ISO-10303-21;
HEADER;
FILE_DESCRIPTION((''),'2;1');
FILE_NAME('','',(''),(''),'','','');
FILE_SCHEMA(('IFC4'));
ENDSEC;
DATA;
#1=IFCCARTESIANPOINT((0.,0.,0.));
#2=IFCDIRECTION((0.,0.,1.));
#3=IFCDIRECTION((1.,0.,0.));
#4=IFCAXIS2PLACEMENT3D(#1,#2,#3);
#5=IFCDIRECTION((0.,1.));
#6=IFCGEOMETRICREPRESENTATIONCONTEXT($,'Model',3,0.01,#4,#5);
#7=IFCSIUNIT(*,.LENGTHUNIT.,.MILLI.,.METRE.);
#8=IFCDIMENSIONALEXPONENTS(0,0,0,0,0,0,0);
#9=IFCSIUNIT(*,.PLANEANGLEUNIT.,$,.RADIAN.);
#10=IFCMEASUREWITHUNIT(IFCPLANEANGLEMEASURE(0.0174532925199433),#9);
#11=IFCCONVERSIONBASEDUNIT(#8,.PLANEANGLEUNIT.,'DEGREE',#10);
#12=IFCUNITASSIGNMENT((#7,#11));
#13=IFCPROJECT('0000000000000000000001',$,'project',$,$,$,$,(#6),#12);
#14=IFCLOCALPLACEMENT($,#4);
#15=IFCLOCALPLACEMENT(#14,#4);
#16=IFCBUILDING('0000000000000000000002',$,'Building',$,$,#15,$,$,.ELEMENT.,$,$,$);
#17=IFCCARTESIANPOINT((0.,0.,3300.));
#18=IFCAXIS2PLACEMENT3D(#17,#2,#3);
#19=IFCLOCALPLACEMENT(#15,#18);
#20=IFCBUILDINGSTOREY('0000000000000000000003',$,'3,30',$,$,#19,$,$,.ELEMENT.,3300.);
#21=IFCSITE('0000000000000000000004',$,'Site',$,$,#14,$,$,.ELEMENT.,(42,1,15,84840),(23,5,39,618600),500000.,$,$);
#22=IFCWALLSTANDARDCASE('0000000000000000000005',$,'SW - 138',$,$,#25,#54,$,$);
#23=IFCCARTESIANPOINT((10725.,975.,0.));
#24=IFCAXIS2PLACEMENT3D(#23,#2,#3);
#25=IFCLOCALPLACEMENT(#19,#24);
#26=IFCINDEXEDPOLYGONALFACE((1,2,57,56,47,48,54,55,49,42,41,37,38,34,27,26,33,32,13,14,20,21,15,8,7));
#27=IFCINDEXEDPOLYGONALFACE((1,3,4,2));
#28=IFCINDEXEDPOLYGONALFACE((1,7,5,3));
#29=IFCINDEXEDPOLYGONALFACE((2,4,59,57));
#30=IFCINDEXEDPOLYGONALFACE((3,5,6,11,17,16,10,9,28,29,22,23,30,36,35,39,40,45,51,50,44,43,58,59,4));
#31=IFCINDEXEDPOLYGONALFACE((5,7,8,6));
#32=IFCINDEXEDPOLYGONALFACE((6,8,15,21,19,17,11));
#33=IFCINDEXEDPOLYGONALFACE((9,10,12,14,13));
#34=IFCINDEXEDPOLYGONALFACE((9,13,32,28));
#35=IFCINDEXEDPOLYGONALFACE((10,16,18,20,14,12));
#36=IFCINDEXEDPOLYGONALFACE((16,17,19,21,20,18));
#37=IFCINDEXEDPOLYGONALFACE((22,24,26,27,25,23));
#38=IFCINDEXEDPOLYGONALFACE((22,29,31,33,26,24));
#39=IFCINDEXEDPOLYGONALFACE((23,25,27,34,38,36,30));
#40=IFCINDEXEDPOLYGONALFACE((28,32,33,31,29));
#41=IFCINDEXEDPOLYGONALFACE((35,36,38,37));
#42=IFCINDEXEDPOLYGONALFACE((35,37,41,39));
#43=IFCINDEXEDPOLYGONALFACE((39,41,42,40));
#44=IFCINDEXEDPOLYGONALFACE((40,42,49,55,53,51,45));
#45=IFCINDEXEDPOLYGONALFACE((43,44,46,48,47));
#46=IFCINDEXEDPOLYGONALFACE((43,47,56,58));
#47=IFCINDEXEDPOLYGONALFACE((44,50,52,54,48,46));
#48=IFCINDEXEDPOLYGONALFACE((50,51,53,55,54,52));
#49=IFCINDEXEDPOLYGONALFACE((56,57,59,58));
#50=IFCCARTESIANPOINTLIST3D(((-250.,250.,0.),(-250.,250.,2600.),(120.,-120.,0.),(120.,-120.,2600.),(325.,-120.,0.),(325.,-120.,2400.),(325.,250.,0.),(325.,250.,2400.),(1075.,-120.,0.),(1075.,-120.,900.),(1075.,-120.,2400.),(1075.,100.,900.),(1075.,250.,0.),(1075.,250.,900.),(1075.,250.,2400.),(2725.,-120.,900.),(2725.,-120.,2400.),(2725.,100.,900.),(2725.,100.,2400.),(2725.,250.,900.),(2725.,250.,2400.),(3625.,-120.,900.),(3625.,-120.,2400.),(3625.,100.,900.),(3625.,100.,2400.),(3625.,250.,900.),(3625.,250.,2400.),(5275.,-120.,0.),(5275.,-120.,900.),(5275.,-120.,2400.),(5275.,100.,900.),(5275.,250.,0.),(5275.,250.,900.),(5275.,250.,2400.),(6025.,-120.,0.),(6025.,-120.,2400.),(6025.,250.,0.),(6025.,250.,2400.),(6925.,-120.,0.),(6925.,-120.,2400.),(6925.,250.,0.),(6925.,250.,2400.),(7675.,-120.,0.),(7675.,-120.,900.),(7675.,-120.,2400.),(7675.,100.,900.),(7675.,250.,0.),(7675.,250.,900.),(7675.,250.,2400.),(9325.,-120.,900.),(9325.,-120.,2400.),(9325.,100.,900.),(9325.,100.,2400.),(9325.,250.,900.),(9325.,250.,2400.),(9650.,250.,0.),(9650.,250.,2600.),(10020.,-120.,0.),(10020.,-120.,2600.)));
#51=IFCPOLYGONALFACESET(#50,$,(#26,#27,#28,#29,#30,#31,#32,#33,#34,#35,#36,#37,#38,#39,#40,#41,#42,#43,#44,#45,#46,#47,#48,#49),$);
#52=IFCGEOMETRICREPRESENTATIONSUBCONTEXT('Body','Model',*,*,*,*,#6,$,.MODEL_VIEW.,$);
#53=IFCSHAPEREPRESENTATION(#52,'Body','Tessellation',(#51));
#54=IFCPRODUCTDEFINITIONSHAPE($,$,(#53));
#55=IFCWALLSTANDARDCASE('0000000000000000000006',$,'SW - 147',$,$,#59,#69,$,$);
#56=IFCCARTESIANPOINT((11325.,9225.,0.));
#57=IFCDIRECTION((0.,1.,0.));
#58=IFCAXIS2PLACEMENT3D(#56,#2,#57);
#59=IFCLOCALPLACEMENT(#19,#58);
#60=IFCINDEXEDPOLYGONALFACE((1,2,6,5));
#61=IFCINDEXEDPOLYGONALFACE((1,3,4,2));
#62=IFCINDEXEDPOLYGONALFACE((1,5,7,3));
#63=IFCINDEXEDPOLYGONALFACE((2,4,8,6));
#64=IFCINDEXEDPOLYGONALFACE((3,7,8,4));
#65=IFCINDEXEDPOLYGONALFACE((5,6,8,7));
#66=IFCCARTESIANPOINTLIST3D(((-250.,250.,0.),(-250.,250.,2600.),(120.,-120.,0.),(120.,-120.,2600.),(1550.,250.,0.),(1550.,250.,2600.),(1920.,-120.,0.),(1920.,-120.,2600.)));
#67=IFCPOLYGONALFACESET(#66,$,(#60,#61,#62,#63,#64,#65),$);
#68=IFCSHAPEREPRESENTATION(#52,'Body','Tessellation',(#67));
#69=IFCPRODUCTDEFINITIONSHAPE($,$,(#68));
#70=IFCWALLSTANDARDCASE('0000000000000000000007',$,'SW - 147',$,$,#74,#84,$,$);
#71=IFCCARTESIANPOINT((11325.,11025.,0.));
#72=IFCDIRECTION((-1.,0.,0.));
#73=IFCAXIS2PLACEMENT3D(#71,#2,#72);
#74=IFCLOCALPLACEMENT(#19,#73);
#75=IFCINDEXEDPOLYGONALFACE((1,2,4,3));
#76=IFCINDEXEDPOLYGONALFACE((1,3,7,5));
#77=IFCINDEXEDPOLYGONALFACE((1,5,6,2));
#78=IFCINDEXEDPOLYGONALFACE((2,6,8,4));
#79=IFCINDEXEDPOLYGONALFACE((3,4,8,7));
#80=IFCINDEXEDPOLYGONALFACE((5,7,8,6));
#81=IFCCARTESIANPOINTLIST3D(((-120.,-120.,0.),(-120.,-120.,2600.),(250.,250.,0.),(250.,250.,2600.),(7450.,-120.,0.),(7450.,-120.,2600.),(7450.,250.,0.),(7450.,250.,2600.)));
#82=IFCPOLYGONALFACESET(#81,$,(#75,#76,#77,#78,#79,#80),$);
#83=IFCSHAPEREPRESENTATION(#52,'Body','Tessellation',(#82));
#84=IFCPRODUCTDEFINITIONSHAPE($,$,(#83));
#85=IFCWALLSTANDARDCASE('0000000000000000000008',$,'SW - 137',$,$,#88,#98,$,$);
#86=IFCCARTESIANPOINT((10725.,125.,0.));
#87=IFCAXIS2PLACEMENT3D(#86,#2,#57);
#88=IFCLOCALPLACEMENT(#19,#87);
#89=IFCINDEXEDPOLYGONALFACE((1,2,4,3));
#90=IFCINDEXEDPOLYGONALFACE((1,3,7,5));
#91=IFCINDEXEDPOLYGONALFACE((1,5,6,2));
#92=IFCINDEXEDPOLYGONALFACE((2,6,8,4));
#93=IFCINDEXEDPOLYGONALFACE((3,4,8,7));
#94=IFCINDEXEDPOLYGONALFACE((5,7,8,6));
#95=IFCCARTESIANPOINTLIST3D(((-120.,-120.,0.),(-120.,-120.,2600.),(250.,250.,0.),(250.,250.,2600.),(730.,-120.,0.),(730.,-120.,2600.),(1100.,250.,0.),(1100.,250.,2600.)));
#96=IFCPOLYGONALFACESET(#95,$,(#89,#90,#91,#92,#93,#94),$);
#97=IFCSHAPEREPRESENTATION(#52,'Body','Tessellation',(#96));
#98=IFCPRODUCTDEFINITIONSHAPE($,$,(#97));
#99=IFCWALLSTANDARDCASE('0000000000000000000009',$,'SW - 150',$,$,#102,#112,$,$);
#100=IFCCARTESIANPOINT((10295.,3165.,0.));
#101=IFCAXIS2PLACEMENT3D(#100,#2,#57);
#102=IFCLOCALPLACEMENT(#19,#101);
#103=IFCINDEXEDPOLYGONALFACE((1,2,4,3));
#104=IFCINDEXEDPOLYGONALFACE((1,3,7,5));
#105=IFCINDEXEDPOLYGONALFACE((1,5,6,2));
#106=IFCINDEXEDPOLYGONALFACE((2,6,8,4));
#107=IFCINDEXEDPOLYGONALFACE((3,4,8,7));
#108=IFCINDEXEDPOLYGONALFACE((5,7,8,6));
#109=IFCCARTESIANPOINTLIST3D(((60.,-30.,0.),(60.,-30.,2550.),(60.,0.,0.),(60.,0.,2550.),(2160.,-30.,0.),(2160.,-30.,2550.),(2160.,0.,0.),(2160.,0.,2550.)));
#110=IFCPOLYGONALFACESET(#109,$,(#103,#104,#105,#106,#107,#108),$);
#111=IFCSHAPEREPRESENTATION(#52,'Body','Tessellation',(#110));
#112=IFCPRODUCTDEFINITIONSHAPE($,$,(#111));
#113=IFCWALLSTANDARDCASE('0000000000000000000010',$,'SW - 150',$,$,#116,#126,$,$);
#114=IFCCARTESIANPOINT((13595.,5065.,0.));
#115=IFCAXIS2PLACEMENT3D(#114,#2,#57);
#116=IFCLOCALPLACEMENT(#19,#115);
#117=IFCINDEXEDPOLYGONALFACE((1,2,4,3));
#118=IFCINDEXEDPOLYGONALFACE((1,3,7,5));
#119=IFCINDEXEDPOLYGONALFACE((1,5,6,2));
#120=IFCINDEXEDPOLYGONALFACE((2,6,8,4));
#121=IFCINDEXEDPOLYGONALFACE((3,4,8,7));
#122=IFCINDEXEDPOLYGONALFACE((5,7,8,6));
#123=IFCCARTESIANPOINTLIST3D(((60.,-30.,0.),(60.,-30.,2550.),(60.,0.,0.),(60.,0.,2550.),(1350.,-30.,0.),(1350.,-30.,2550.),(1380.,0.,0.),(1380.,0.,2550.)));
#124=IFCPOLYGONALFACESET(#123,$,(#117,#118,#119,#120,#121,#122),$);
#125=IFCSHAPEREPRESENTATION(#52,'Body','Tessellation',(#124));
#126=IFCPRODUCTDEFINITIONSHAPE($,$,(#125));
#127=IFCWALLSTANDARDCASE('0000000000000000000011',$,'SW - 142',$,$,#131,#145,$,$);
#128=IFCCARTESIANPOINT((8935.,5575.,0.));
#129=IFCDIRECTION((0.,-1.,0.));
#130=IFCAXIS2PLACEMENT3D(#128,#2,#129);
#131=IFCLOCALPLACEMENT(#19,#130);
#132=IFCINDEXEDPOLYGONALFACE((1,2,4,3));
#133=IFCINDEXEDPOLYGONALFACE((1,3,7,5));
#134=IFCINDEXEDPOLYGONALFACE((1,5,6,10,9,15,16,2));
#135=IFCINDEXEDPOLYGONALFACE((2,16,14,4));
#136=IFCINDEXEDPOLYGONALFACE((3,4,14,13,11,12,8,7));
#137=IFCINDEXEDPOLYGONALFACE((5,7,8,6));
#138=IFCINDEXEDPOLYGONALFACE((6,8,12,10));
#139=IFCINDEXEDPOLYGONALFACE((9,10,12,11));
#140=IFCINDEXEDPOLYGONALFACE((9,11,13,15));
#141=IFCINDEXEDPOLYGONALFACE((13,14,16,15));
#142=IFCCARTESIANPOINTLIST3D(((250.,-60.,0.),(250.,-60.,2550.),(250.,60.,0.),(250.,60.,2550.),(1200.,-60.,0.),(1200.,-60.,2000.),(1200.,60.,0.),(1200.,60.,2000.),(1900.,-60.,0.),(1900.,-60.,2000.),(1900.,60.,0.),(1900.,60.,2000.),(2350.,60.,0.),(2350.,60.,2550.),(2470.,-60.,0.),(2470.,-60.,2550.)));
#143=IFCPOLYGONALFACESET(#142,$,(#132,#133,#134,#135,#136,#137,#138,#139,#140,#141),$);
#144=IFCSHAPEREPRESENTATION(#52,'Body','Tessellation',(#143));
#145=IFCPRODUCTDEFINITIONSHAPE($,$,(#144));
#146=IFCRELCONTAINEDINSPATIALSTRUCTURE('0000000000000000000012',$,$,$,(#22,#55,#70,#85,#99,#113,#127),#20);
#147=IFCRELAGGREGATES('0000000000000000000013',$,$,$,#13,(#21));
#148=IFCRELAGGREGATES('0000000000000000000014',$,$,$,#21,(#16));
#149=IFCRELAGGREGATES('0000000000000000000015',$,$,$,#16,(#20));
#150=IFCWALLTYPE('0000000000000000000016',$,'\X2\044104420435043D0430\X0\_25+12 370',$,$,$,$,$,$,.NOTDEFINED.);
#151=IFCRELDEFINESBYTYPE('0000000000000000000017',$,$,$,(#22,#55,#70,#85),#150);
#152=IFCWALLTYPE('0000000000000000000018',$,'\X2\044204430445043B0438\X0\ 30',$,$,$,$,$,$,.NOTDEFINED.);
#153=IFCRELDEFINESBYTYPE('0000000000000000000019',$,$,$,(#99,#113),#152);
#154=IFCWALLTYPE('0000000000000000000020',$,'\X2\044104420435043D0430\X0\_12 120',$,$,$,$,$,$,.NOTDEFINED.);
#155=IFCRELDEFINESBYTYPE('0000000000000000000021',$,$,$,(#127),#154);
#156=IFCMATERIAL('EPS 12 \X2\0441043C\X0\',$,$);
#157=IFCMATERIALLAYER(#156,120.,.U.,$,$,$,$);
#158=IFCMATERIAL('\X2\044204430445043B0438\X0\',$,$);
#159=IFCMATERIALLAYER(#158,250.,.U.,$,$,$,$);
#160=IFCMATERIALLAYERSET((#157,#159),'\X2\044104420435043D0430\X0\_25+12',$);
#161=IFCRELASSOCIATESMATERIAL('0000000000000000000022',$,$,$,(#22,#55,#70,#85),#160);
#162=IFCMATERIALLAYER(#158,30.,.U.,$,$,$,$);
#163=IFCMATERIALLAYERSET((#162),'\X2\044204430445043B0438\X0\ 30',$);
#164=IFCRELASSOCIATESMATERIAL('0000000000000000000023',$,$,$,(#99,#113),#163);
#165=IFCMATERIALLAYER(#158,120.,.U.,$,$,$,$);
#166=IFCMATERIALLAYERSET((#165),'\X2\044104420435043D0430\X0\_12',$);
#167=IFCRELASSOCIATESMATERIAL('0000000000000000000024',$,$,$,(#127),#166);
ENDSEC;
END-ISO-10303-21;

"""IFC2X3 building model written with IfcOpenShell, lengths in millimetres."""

from ifc_helpers import new_model, entity, si_unit, converted_unit, direction, frame, origin_with_axes, origin_2d_with_axis, place, context, subcontext, project, spatial, polyline, rectangle, outline, extrude, material, layer, layer_set, layer_usage, type_object, element, save


model = new_model("IFC2X3")

# Units and contexts
model_context = context("Model", 3, precision=0.01, world=origin_with_axes(), true_north=direction((0.0, 1.0)))
body_context = subcontext(model_context, "Body", "Model", "MODEL_VIEW")
ifc_project = project(units=[si_unit("LENGTHUNIT", "METRE", prefix="MILLI"), converted_unit("PLANEANGLEUNIT", "DEGREE", entity("IfcPlaneAngleMeasure", 0.0174532925199433), si_unit("PLANEANGLEUNIT", "RADIAN"), dimensions=[0, 0, 0, 0, 0, 0, 0])], contexts=[model_context])

# Site, building, storey
site_placement = place(None, origin_with_axes())
site = spatial("IfcSite", under=ifc_project, at=site_placement, Name="Site", CompositionType="ELEMENT", RefLatitude=(42, 1, 15, 84840), RefLongitude=(23, 5, 39, 618600), RefElevation=500000.0)
building_placement = place(site_placement, origin_with_axes())
building = spatial("IfcBuilding", under=site, at=building_placement, Name="Building", CompositionType="ELEMENT")
storey_placement = place(building_placement, frame((0.0, 0.0, 3300.0), z_axis=(0.0, 0.0, 1.0), x_axis=(1.0, 0.0, 0.0)))
storey = spatial("IfcBuildingStorey", under=building, at=storey_placement, Name="3,30", CompositionType="ELEMENT", Elevation=3300.0)

# Wall, openings
ifc_material_1 = material(Name="EPS 12 см")
ifc_layer_1 = layer(ifc_material_1, 120.0, ventilated="UNKNOWN")
ifc_material_2 = material(Name="тухли")
ifc_layer_2 = layer(ifc_material_2, 250.0, ventilated="UNKNOWN")
ifc_layer_set_1 = layer_set([ifc_layer_1, ifc_layer_2], Name="стена_25+12")
ifc_layer_usage_1 = layer_usage(ifc_layer_set_1, "AXIS2", "POSITIVE", -120.0)
wall_type_1 = type_object("IfcWallType", Name="стена_25+12 370", PredefinedType="NOTDEFINED")
wall_1_placement = place(storey_placement, frame((10725.0, 975.0, 0.0), z_axis=(0.0, 0.0, 1.0), x_axis=(1.0, 0.0, 0.0)))
wall_1 = element("IfcWallStandardCase", 1, at=wall_1_placement, inside=storey, type_object=wall_type_1, material=ifc_layer_usage_1, Name="SW - 138", context=body_context, shape_type="SweptSolid", body=[
    extrude(outline(polyline([(120.0, -120.0), (10020.0, -120.0), (9650.0, 250.0), (-250.0, 250.0), (120.0, -120.0)])), origin_with_axes(), (0.0, 0.0, 1.0), 2600.0),
])
opening_1_placement = place(wall_1_placement, frame((4450.0, 0.0, 900.0), z_axis=(0.0, 0.0, 1.0), x_axis=(1.0, 0.0, 0.0)))
element("IfcOpeningElement", 2, at=opening_1_placement, cuts=wall_1, context=body_context, shape_type="SweptSolid", body=[
    extrude(rectangle(XDim=1650.0, YDim=1500.0, at=origin_2d_with_axis()), frame((0.0, 100.0, 750.0), z_axis=(0.0, -1.0, 0.0), x_axis=(-1.0, 0.0, 0.0)), (0.0, 0.0, 1.0), 590.0),
    extrude(rectangle(XDim=1650.0, YDim=1500.0, at=origin_2d_with_axis()), frame((0.0, 100.0, 750.0), z_axis=(0.0, 1.0, 0.0), x_axis=(-1.0, 0.0, 0.0)), (0.0, 0.0, 1.0), 520.0),
])
opening_2_placement = place(wall_1_placement, frame((1900.0, 0.0, 900.0), z_axis=(0.0, 0.0, 1.0), x_axis=(1.0, 0.0, 0.0)))
element("IfcOpeningElement", 3, at=opening_2_placement, cuts=wall_1, context=body_context, shape_type="SweptSolid", body=[
    extrude(rectangle(XDim=1650.0, YDim=1500.0, at=origin_2d_with_axis()), frame((0.0, 100.0, 750.0), z_axis=(0.0, 1.0, 0.0), x_axis=(1.0, 0.0, 0.0)), (0.0, 0.0, -1.0), 590.0),
    extrude(rectangle(XDim=1650.0, YDim=1500.0, at=origin_2d_with_axis()), frame((0.0, 100.0, 750.0), z_axis=(0.0, -1.0, 0.0), x_axis=(1.0, 0.0, 0.0)), (0.0, 0.0, -1.0), 520.0),
])
opening_3_placement = place(wall_1_placement, frame((8500.0, 0.0, 900.0), z_axis=(0.0, 0.0, 1.0), x_axis=(1.0, 0.0, 0.0)))
element("IfcOpeningElement", 4, at=opening_3_placement, cuts=wall_1, context=body_context, shape_type="SweptSolid", body=[
    extrude(rectangle(XDim=1650.0, YDim=1500.0, at=origin_2d_with_axis()), frame((0.0, 100.0, 750.0), z_axis=(0.0, 1.0, 0.0), x_axis=(1.0, 0.0, 0.0)), (0.0, 0.0, -1.0), 590.0),
    extrude(rectangle(XDim=1650.0, YDim=1500.0, at=origin_2d_with_axis()), frame((0.0, 100.0, 750.0), z_axis=(0.0, -1.0, 0.0), x_axis=(1.0, 0.0, 0.0)), (0.0, 0.0, -1.0), 520.0),
])
opening_4_placement = place(wall_1_placement, frame((5650.0, 0.0, 0.0), z_axis=(0.0, 0.0, 1.0), x_axis=(1.0, 0.0, 0.0)))
element("IfcOpeningElement", 5, at=opening_4_placement, cuts=wall_1, context=body_context, shape_type="SweptSolid", body=[
    extrude(rectangle(XDim=750.0, YDim=2400.0, at=origin_2d_with_axis()), frame((0.0, -370.0, 1200.0), z_axis=(0.0, 1.0, 0.0), x_axis=(1.0, 0.0, 0.0)), (0.0, 0.0, 1.0), 1110.0),
])
opening_5_placement = place(wall_1_placement, frame((700.0, 0.0, 0.0), z_axis=(0.0, 0.0, 1.0), x_axis=(1.0, 0.0, 0.0)))
element("IfcOpeningElement", 6, at=opening_5_placement, cuts=wall_1, context=body_context, shape_type="SweptSolid", body=[
    extrude(rectangle(XDim=750.0, YDim=2400.0, at=origin_2d_with_axis()), frame((0.0, -370.0, 1200.0), z_axis=(0.0, -1.0, 0.0), x_axis=(-1.0, 0.0, 0.0)), (0.0, 0.0, -1.0), 1110.0),
])
opening_6_placement = place(wall_1_placement, frame((7300.0, 0.0, 0.0), z_axis=(0.0, 0.0, 1.0), x_axis=(1.0, 0.0, 0.0)))
element("IfcOpeningElement", 7, at=opening_6_placement, cuts=wall_1, context=body_context, shape_type="SweptSolid", body=[
    extrude(rectangle(XDim=750.0, YDim=2400.0, at=origin_2d_with_axis()), frame((0.0, -370.0, 1200.0), z_axis=(0.0, -1.0, 0.0), x_axis=(-1.0, 0.0, 0.0)), (0.0, 0.0, -1.0), 1110.0),
])

# Walls
ifc_layer_usage_2 = layer_usage(ifc_layer_set_1, "AXIS2", "POSITIVE", -120.0)
wall_2_placement = place(storey_placement, frame((11325.0, 9225.0, 0.0), z_axis=(0.0, 0.0, 1.0), x_axis=(0.0, 1.0, 0.0)))
element("IfcWallStandardCase", 8, at=wall_2_placement, inside=storey, type_object=wall_type_1, material=ifc_layer_usage_2, Name="SW - 147", context=body_context, shape_type="SweptSolid", body=[
    extrude(outline(polyline([(120.0, -120.0), (1920.0, -120.0), (1550.0, 250.0), (-250.0, 250.0), (120.0, -120.0)])), origin_with_axes(), (0.0, 0.0, 1.0), 2600.0),
])
ifc_layer_usage_3 = layer_usage(ifc_layer_set_1, "AXIS2", "POSITIVE", -120.0)
wall_3_placement = place(storey_placement, frame((11325.0, 11025.0, 0.0), z_axis=(0.0, 0.0, 1.0), x_axis=(-1.0, 0.0, 0.0)))
element("IfcWallStandardCase", 9, at=wall_3_placement, inside=storey, type_object=wall_type_1, material=ifc_layer_usage_3, Name="SW - 147", context=body_context, shape_type="SweptSolid", body=[
    extrude(outline(polyline([(-120.0, -120.0), (7450.0, -120.0), (7450.0, 250.0), (250.0, 250.0), (-120.0, -120.0)])), origin_with_axes(), (0.0, 0.0, 1.0), 2600.0),
])
ifc_layer_usage_4 = layer_usage(ifc_layer_set_1, "AXIS2", "POSITIVE", -120.0)
wall_4_placement = place(storey_placement, frame((10725.0, 125.0, 0.0), z_axis=(0.0, 0.0, 1.0), x_axis=(0.0, 1.0, 0.0)))
element("IfcWallStandardCase", 10, at=wall_4_placement, inside=storey, type_object=wall_type_1, material=ifc_layer_usage_4, Name="SW - 137", context=body_context, shape_type="SweptSolid", body=[
    extrude(outline(polyline([(-120.0, -120.0), (730.0, -120.0), (1100.0, 250.0), (250.0, 250.0), (-120.0, -120.0)])), origin_with_axes(), (0.0, 0.0, 1.0), 2600.0),
])
ifc_layer_3 = layer(ifc_material_2, 30.0, ventilated="UNKNOWN")
ifc_layer_set_2 = layer_set([ifc_layer_3], Name="тухли 30")
ifc_layer_usage_5 = layer_usage(ifc_layer_set_2, "AXIS2", "NEGATIVE", 0.0)
wall_type_2 = type_object("IfcWallType", Name="тухли 30", PredefinedType="NOTDEFINED")
wall_5_placement = place(storey_placement, frame((10295.0, 3165.0, 0.0), z_axis=(0.0, 0.0, 1.0), x_axis=(0.0, 1.0, 0.0)))
element("IfcWallStandardCase", 11, at=wall_5_placement, inside=storey, type_object=wall_type_2, material=ifc_layer_usage_5, Name="SW - 150", context=body_context, shape_type="SweptSolid", body=[
    extrude(outline(polyline([(60.0, -30.0), (2160.0, -30.0), (2160.0, 0.0), (60.0, 0.0), (60.0, -30.0)])), origin_with_axes(), (0.0, 0.0, 1.0), 2550.0),
])
ifc_layer_usage_6 = layer_usage(ifc_layer_set_2, "AXIS2", "NEGATIVE", 0.0)
wall_6_placement = place(storey_placement, frame((13595.0, 5065.0, 0.0), z_axis=(0.0, 0.0, 1.0), x_axis=(0.0, 1.0, 0.0)))
element("IfcWallStandardCase", 12, at=wall_6_placement, inside=storey, type_object=wall_type_2, material=ifc_layer_usage_6, Name="SW - 150", context=body_context, shape_type="SweptSolid", body=[
    extrude(outline(polyline([(60.0, -30.0), (1350.0, -30.0), (1380.0, 0.0), (60.0, 0.0), (60.0, -30.0)])), origin_with_axes(), (0.0, 0.0, 1.0), 2550.0),
])

# Shared definitions
ifc_layer_4 = layer(ifc_material_2, 120.0, ventilated="UNKNOWN")
ifc_layer_set_3 = layer_set([ifc_layer_4], Name="стена_12")
wall_type_3 = type_object("IfcWallType", Name="стена_12 120", PredefinedType="NOTDEFINED")

# Wall, opening
ifc_layer_usage_7 = layer_usage(ifc_layer_set_3, "AXIS2", "POSITIVE", -60.0)
wall_7_placement = place(storey_placement, frame((8935.0, 5575.0, 0.0), z_axis=(0.0, 0.0, 1.0), x_axis=(0.0, -1.0, 0.0)))
wall_7 = element("IfcWallStandardCase", 13, at=wall_7_placement, inside=storey, type_object=wall_type_3, material=ifc_layer_usage_7, Name="SW - 142", context=body_context, shape_type="SweptSolid", body=[
    extrude(outline(polyline([(250.0, -60.0), (2470.0, -60.0), (2350.0, 60.0), (250.0, 60.0), (250.0, -60.0)])), origin_with_axes(), (0.0, 0.0, 1.0), 2550.0),
])
opening_7_placement = place(wall_7_placement, frame((1550.0, 0.0, 0.0), z_axis=(0.0, 0.0, 1.0), x_axis=(1.0, 0.0, 0.0)))
element("IfcOpeningElement", 14, at=opening_7_placement, cuts=wall_7, context=body_context, shape_type="SweptSolid", body=[
    extrude(rectangle(XDim=700.0, YDim=2000.0, at=origin_2d_with_axis()), frame((0.0, -120.0, 1000.0), z_axis=(0.0, -1.0, 0.0), x_axis=(-1.0, 0.0, 0.0)), (0.0, 0.0, -1.0), 360.0),
])

save(model, "model.ifc")
